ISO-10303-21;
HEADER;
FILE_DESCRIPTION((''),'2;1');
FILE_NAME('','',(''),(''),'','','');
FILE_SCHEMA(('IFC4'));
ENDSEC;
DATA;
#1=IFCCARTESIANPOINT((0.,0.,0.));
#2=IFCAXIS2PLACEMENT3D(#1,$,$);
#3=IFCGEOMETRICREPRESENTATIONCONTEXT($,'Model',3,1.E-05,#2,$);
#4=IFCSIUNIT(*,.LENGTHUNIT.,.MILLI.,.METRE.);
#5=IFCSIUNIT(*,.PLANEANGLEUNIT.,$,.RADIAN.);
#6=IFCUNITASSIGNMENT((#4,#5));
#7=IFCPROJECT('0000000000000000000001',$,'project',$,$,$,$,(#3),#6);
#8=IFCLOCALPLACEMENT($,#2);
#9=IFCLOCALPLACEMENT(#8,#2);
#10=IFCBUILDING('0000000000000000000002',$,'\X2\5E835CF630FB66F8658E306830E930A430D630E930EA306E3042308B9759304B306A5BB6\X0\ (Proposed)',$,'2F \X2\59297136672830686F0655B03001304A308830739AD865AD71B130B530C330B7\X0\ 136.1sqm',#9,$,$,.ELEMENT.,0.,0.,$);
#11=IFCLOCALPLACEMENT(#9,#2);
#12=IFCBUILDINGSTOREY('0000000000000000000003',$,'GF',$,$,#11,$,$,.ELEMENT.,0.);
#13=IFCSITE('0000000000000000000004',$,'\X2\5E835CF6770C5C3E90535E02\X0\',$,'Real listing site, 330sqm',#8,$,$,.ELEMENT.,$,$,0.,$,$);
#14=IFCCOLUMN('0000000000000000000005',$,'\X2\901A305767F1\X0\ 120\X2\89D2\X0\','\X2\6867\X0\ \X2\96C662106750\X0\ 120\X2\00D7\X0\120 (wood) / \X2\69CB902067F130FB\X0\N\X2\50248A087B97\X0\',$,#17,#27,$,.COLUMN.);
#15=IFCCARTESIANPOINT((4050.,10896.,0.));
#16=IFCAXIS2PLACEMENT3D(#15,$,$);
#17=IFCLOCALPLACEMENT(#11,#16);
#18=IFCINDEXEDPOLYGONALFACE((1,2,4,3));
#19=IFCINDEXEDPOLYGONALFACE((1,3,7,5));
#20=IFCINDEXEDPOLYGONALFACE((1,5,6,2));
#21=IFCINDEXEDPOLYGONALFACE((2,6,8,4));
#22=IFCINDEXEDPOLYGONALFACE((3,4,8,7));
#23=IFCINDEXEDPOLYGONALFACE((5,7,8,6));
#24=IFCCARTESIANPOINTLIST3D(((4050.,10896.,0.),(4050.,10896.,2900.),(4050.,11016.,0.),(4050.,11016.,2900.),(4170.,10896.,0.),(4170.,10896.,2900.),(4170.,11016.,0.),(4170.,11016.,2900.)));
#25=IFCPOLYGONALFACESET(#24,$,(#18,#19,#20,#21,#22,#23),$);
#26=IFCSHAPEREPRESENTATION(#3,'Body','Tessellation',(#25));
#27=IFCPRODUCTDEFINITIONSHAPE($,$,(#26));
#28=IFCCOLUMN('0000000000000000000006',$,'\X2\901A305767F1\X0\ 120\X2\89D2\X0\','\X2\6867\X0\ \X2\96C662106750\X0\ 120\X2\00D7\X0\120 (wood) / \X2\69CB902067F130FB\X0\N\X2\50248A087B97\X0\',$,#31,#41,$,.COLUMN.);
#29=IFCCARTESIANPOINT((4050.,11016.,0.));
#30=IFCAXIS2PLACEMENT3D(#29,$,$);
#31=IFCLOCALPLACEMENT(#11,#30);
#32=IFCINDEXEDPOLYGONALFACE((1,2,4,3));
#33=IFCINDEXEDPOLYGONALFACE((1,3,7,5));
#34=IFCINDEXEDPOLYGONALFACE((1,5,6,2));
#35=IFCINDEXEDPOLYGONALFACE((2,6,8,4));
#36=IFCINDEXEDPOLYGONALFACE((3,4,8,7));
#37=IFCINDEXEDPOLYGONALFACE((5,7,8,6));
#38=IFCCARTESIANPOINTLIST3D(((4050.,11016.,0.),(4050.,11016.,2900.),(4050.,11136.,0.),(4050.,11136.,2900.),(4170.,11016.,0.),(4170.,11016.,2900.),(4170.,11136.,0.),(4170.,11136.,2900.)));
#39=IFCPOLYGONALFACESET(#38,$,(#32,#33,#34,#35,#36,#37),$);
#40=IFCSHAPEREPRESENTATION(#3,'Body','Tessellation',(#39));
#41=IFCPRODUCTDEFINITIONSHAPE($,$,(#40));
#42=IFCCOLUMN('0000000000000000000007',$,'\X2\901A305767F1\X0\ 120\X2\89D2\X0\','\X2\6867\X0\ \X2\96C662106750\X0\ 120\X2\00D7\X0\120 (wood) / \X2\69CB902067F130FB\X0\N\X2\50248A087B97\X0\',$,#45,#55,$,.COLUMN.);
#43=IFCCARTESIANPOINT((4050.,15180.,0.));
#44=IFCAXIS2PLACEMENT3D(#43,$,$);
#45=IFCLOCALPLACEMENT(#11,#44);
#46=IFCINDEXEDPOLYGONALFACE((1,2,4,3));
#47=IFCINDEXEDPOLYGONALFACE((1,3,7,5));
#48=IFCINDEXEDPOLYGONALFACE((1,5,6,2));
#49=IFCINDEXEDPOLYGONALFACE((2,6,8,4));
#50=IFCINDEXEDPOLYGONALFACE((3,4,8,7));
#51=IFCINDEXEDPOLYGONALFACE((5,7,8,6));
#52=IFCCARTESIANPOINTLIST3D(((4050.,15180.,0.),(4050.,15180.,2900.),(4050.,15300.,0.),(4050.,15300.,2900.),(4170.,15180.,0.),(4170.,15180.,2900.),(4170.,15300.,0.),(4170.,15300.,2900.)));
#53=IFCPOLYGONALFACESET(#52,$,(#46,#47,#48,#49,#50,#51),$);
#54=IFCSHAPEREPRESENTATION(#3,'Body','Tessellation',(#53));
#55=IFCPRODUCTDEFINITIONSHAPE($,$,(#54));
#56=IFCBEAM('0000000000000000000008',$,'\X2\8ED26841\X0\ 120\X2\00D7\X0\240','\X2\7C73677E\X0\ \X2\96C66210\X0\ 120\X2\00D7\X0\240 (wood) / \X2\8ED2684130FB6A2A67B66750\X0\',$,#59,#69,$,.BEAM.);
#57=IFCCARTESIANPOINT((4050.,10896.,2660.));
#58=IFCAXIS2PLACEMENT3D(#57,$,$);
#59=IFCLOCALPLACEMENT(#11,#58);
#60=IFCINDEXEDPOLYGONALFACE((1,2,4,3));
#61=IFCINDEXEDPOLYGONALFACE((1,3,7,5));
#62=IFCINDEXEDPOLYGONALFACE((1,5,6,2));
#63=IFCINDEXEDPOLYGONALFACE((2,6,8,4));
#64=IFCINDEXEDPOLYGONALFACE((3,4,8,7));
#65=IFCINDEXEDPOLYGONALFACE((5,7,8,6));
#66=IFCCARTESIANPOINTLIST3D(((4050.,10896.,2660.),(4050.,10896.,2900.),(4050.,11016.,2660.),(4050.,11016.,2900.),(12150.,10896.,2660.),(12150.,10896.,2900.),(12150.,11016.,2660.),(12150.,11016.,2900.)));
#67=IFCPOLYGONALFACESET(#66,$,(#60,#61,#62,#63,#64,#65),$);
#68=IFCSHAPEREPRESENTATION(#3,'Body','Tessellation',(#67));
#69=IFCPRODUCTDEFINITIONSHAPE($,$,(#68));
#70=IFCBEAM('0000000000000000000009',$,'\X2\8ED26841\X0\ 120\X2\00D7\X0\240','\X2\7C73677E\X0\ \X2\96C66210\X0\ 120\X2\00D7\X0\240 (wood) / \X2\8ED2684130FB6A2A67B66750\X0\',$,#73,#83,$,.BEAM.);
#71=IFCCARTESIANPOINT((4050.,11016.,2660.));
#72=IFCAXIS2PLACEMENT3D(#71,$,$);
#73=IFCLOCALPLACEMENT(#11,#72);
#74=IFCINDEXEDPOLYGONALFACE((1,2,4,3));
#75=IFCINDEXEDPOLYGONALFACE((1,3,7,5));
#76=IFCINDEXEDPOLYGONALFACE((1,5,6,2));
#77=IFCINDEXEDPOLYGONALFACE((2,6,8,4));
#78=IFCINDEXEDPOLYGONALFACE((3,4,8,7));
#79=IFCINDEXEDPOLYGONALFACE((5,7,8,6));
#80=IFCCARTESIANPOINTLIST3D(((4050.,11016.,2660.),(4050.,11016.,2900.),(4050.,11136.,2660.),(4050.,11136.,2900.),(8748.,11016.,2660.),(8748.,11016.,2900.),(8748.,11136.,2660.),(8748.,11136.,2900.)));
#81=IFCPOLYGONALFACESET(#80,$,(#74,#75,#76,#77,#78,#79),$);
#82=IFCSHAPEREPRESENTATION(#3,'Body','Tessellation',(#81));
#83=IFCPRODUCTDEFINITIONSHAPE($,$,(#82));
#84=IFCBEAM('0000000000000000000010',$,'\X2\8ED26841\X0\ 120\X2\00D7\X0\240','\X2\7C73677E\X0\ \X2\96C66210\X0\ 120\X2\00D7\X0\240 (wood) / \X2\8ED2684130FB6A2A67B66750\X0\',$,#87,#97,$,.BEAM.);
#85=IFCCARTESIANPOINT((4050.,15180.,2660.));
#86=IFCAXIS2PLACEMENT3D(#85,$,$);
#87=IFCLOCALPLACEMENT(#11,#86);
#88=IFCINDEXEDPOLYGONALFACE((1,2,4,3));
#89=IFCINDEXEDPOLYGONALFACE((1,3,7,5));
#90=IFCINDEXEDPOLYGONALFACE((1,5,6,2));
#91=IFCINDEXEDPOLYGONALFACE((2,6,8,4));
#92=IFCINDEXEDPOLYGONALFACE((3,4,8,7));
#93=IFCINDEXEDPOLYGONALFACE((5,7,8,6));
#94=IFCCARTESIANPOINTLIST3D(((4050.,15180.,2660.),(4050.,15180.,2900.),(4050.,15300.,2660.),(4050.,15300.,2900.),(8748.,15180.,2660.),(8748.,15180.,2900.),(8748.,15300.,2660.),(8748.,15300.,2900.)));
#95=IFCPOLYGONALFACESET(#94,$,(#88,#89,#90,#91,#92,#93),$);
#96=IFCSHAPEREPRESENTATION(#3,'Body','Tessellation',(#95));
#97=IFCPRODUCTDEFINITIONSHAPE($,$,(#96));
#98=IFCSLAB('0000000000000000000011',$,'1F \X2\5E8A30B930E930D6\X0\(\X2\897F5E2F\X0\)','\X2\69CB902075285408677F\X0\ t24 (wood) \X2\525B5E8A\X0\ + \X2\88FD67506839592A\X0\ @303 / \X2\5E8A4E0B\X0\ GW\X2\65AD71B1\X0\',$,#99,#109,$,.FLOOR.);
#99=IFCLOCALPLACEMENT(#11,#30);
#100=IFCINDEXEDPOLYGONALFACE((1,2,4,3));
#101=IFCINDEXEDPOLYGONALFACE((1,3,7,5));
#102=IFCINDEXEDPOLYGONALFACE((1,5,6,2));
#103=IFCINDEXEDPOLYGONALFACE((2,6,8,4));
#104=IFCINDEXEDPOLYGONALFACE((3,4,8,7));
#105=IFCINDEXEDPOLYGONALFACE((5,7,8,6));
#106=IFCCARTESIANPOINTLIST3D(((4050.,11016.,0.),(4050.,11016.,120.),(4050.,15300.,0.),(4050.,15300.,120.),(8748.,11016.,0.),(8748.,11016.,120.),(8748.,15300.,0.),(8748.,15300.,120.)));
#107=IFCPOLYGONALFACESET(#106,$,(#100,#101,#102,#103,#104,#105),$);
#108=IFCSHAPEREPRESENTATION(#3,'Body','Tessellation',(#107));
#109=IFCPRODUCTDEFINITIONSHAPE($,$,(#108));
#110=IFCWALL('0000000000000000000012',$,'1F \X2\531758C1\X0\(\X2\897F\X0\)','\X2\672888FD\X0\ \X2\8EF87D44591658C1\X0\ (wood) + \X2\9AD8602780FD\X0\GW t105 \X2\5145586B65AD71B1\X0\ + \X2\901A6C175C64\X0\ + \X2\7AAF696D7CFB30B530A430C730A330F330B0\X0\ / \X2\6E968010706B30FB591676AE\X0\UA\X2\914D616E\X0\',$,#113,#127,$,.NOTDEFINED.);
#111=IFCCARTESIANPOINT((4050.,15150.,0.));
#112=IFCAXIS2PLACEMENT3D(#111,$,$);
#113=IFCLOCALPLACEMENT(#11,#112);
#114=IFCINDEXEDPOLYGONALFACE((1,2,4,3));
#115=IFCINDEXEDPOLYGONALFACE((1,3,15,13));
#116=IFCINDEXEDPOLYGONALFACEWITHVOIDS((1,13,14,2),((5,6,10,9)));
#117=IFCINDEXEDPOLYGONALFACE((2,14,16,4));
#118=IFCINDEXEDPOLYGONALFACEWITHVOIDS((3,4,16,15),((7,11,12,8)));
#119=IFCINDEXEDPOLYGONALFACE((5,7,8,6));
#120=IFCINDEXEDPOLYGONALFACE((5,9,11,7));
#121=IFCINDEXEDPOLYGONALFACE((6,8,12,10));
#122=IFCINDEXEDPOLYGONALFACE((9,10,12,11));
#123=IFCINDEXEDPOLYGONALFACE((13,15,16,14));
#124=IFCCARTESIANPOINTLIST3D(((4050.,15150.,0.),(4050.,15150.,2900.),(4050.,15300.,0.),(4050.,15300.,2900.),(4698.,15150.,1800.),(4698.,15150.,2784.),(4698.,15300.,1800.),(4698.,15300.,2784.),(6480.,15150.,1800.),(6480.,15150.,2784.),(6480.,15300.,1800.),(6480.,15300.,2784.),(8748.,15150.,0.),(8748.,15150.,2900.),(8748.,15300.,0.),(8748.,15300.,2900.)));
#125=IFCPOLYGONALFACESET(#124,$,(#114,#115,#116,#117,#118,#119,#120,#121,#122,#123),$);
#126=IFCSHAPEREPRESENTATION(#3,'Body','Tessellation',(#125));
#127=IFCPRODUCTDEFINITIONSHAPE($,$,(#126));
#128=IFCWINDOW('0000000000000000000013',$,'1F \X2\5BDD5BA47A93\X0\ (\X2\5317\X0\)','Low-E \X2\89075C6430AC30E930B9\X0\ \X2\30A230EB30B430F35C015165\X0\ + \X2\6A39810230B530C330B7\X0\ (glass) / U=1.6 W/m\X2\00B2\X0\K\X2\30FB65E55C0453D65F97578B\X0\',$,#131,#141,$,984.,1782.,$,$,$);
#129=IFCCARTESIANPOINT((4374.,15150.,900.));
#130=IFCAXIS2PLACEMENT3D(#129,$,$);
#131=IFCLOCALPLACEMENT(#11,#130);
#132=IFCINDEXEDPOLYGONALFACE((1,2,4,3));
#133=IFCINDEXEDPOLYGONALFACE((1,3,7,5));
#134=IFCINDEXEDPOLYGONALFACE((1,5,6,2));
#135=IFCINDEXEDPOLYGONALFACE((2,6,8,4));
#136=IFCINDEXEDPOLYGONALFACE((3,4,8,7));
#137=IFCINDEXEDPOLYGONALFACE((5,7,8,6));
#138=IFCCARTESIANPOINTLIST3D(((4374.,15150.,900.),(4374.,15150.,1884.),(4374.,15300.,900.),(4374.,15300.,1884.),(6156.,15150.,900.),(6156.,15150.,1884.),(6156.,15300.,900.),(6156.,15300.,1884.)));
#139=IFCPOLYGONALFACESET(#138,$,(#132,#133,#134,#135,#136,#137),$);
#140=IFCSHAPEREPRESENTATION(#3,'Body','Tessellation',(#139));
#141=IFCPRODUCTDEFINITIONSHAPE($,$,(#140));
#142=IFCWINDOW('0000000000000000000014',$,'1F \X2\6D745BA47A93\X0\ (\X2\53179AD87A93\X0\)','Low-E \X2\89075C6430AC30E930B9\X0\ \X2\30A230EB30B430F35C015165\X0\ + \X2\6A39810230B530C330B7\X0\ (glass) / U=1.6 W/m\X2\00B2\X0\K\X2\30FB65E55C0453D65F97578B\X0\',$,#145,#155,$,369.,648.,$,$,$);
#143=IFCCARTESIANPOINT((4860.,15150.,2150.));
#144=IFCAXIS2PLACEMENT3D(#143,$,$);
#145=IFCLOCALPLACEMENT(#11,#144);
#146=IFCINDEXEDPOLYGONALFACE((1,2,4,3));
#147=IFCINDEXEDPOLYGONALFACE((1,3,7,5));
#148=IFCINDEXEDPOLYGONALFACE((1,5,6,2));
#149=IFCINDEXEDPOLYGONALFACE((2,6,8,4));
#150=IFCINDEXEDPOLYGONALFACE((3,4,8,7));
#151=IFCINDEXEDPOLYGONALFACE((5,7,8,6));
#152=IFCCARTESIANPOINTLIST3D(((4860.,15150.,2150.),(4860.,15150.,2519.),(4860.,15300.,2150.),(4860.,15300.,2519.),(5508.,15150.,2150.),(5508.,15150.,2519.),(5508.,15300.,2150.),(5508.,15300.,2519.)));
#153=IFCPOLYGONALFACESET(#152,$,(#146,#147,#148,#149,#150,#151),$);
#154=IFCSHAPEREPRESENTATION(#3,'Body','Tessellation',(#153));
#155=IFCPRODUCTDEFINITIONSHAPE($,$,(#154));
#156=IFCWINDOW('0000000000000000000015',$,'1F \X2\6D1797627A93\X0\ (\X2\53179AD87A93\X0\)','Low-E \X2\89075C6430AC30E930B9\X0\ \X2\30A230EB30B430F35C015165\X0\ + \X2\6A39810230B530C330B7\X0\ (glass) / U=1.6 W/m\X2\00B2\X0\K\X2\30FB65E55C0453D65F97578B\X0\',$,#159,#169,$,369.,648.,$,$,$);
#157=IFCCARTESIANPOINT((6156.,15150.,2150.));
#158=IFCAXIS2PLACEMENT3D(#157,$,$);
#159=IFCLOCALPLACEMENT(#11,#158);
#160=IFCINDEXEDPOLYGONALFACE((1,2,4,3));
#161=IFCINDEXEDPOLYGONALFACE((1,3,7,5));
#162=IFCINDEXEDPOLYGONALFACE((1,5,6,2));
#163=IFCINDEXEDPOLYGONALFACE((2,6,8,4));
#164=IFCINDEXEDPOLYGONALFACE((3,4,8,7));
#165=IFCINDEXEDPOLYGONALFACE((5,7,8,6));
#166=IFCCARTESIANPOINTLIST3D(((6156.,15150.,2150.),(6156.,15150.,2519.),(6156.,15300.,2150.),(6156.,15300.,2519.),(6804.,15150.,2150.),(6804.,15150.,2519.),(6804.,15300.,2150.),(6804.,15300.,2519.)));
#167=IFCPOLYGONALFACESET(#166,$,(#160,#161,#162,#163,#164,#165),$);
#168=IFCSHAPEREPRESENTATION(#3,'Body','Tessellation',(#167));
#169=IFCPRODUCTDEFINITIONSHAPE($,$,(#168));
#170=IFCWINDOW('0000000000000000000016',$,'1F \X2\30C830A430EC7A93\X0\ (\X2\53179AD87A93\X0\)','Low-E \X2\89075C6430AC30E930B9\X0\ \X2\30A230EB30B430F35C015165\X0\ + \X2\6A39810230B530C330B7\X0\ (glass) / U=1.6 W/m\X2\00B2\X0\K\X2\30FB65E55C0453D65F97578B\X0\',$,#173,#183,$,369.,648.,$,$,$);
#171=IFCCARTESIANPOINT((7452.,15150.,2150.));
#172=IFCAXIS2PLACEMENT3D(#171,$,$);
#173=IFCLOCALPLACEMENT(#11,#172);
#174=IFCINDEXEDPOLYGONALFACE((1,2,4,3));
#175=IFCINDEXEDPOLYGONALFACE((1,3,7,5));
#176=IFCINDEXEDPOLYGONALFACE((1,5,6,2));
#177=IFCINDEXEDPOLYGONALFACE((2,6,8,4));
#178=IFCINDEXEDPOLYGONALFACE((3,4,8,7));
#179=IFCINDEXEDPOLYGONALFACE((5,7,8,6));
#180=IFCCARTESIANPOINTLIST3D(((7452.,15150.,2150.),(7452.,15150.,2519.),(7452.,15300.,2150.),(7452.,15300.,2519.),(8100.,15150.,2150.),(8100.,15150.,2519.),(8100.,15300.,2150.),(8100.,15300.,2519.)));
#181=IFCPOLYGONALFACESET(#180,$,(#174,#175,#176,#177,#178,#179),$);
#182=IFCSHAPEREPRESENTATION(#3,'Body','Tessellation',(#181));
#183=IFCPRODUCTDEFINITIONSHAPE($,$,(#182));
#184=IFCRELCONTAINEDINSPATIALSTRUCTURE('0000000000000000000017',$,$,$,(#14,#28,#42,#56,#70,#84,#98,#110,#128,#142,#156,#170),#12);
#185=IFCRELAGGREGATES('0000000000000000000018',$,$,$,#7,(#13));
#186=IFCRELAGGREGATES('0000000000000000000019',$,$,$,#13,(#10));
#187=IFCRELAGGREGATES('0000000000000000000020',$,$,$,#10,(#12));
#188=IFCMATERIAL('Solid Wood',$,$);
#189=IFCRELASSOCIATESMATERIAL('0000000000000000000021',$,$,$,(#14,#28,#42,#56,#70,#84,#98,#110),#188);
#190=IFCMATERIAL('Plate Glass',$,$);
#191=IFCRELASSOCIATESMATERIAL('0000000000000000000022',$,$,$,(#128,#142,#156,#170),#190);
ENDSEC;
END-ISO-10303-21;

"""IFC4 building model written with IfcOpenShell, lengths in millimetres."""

from ifc_helpers import new_model, si_unit, frame, frame_2d, origin, place, context, project, spatial, rectangle, extrude, material, element, fill, save


model = new_model("IFC4")

# Units and contexts
model_context = context("Model", 3, precision=1e-05, world=origin())
ifc_project = project(units=[si_unit("LENGTHUNIT", "METRE", prefix="MILLI"), si_unit("PLANEANGLEUNIT", "RADIAN")], contexts=[model_context])

# Site, building, storey
site_placement = place(None, origin())
site = spatial("IfcSite", under=ifc_project, at=site_placement, Name="広島県尾道市", ObjectType="Real listing site, 330sqm", CompositionType="ELEMENT", RefElevation=0.0)
building_placement = place(site_placement, origin())
building = spatial("IfcBuilding", under=site, at=building_placement, Name="広島・書斎とライブラリのある静かな家 (Proposed)", ObjectType="2F 天然木と漆喰、および高断熱サッシ 136.1sqm", CompositionType="ELEMENT", ElevationOfRefHeight=0.0, ElevationOfTerrain=0.0)
storey_placement = place(building_placement, origin())
storey = spatial("IfcBuildingStorey", under=building, at=storey_placement, Name="GF", CompositionType="ELEMENT", Elevation=0.0)

# Columns
ifc_material_1 = material(Name="Solid Wood")
column_1_placement = place(storey_placement, frame((4050.0, 10896.0, 0.0)))
element("IfcColumn", 1, at=column_1_placement, inside=storey, material=ifc_material_1, Name="通し柱 120角", Description="桧 集成材 120×120 (wood) / 構造柱・N値計算", PredefinedType="COLUMN", context=model_context, shape_type="SweptSolid", body=[
    extrude(rectangle(XDim=120.0, YDim=120.0, at=frame_2d((60.0, 60.0))), frame((4050.0, 10896.0, 0.0)), (0.0, 0.0, 1.0), 2900.0),
])
column_2_placement = place(storey_placement, frame((4050.0, 11016.0, 0.0)))
element("IfcColumn", 2, at=column_2_placement, inside=storey, material=ifc_material_1, Name="通し柱 120角", Description="桧 集成材 120×120 (wood) / 構造柱・N値計算", PredefinedType="COLUMN", context=model_context, shape_type="SweptSolid", body=[
    extrude(rectangle(XDim=120.0, YDim=120.0, at=frame_2d((60.0, 60.0))), frame((4050.0, 11016.0, 0.0)), (0.0, 0.0, 1.0), 2900.0),
])
column_3_placement = place(storey_placement, frame((4050.0, 15180.0, 0.0)))
element("IfcColumn", 3, at=column_3_placement, inside=storey, material=ifc_material_1, Name="通し柱 120角", Description="桧 集成材 120×120 (wood) / 構造柱・N値計算", PredefinedType="COLUMN", context=model_context, shape_type="SweptSolid", body=[
    extrude(rectangle(XDim=120.0, YDim=120.0, at=frame_2d((60.0, 60.0))), frame((4050.0, 15180.0, 0.0)), (0.0, 0.0, 1.0), 2900.0),
])

# Beams
beam_1_placement = place(storey_placement, frame((4050.0, 10896.0, 2660.0)))
element("IfcBeam", 4, at=beam_1_placement, inside=storey, material=ifc_material_1, Name="軒桁 120×240", Description="米松 集成 120×240 (wood) / 軒桁・横架材", PredefinedType="BEAM", context=model_context, shape_type="SweptSolid", body=[
    extrude(rectangle(XDim=8100.0, YDim=120.0, at=frame_2d((4050.0, 60.0))), frame((4050.0, 10896.0, 2660.0)), (0.0, 0.0, 1.0), 240.0),
])
beam_2_placement = place(storey_placement, frame((4050.0, 11016.0, 2660.0)))
element("IfcBeam", 5, at=beam_2_placement, inside=storey, material=ifc_material_1, Name="軒桁 120×240", Description="米松 集成 120×240 (wood) / 軒桁・横架材", PredefinedType="BEAM", context=model_context, shape_type="SweptSolid", body=[
    extrude(rectangle(XDim=4698.0, YDim=120.0, at=frame_2d((2349.0, 60.0))), frame((4050.0, 11016.0, 2660.0)), (0.0, 0.0, 1.0), 240.0),
])
beam_3_placement = place(storey_placement, frame((4050.0, 15180.0, 2660.0)))
element("IfcBeam", 6, at=beam_3_placement, inside=storey, material=ifc_material_1, Name="軒桁 120×240", Description="米松 集成 120×240 (wood) / 軒桁・横架材", PredefinedType="BEAM", context=model_context, shape_type="SweptSolid", body=[
    extrude(rectangle(XDim=4698.0, YDim=120.0, at=frame_2d((2349.0, 60.0))), frame((4050.0, 15180.0, 2660.0)), (0.0, 0.0, 1.0), 240.0),
])

# Slab
slab_placement = place(storey_placement, frame((4050.0, 11016.0, 0.0)))
element("IfcSlab", 7, at=slab_placement, inside=storey, material=ifc_material_1, Name="1F 床スラブ(西帯)", Description="構造用合板 t24 (wood) 剛床 + 製材根太 @303 / 床下 GW断熱", PredefinedType="FLOOR", context=model_context, shape_type="SweptSolid", body=[
    extrude(rectangle(XDim=4698.0, YDim=4284.0, at=frame_2d((2349.0, 2142.0))), frame((4050.0, 11016.0, 0.0)), (0.0, 0.0, 1.0), 120.0),
])

# Wall, openings, windows
wall_1_placement = place(storey_placement, frame((4050.0, 15150.0, 0.0)))
wall_1 = element("IfcWall", 8, at=wall_1_placement, inside=storey, material=ifc_material_1, Name="1F 北壁(西)", Description="木製 軸組外壁 (wood) + 高性能GW t105 充填断熱 + 通気層 + 窯業系サイディング / 準耐火・外皮UA配慮", PredefinedType="NOTDEFINED", context=model_context, shape_type="SweptSolid", body=[
    extrude(rectangle(XDim=4698.0, YDim=150.0, at=frame_2d((2349.0, 75.0))), frame((4050.0, 15150.0, 0.0)), (0.0, 0.0, 1.0), 2900.0),
])
opening_1_placement = place(storey_placement, frame((4374.0, 15150.0, 900.0)))
opening_1 = element("IfcOpeningElement", 9, at=opening_1_placement, cuts=wall_1, PredefinedType="NOTDEFINED", context=model_context, shape_type="SweptSolid", body=[
    extrude(rectangle(XDim=1782.0, YDim=150.0, at=frame_2d((891.0, 75.0))), frame((4374.0, 15150.0, 900.0)), (0.0, 0.0, 1.0), 984.0),
])
opening_2_placement = place(storey_placement, frame((4860.0, 15150.0, 2150.0)))
opening_2 = element("IfcOpeningElement", 10, at=opening_2_placement, cuts=wall_1, PredefinedType="NOTDEFINED", context=model_context, shape_type="SweptSolid", body=[
    extrude(rectangle(XDim=648.0, YDim=150.0, at=frame_2d((324.0, 75.0))), frame((4860.0, 15150.0, 2150.0)), (0.0, 0.0, 1.0), 369.0),
])
opening_3_placement = place(storey_placement, frame((6156.0, 15150.0, 2150.0)))
opening_3 = element("IfcOpeningElement", 11, at=opening_3_placement, cuts=wall_1, PredefinedType="NOTDEFINED", context=model_context, shape_type="SweptSolid", body=[
    extrude(rectangle(XDim=648.0, YDim=150.0, at=frame_2d((324.0, 75.0))), frame((6156.0, 15150.0, 2150.0)), (0.0, 0.0, 1.0), 369.0),
])
opening_4_placement = place(storey_placement, frame((7452.0, 15150.0, 2150.0)))
opening_4 = element("IfcOpeningElement", 12, at=opening_4_placement, cuts=wall_1, PredefinedType="NOTDEFINED", context=model_context, shape_type="SweptSolid", body=[
    extrude(rectangle(XDim=648.0, YDim=150.0, at=frame_2d((324.0, 75.0))), frame((7452.0, 15150.0, 2150.0)), (0.0, 0.0, 1.0), 369.0),
])
ifc_material_2 = material(Name="Plate Glass")
window_1_placement = place(storey_placement, frame((4374.0, 15150.0, 900.0)))
window_1 = element("IfcWindow", 13, at=window_1_placement, inside=storey, material=ifc_material_2, Name="1F 寝室窓 (北)", Description="Low-E 複層ガラス アルゴン封入 + 樹脂サッシ (glass) / U=1.6 W/m²K・日射取得型", OverallHeight=984.0, OverallWidth=1782.0, context=model_context, shape_type="SweptSolid", body=[
    extrude(rectangle(XDim=1782.0, YDim=150.0, at=frame_2d((891.0, 75.0))), frame((4374.0, 15150.0, 900.0)), (0.0, 0.0, 1.0), 984.0),
])
fill(opening_1, window_1)
window_2_placement = place(storey_placement, frame((4860.0, 15150.0, 2150.0)))
window_2 = element("IfcWindow", 14, at=window_2_placement, inside=storey, material=ifc_material_2, Name="1F 浴室窓 (北高窓)", Description="Low-E 複層ガラス アルゴン封入 + 樹脂サッシ (glass) / U=1.6 W/m²K・日射取得型", OverallHeight=369.0, OverallWidth=648.0, context=model_context, shape_type="SweptSolid", body=[
    extrude(rectangle(XDim=648.0, YDim=150.0, at=frame_2d((324.0, 75.0))), frame((4860.0, 15150.0, 2150.0)), (0.0, 0.0, 1.0), 369.0),
])
fill(opening_2, window_2)
window_3_placement = place(storey_placement, frame((6156.0, 15150.0, 2150.0)))
window_3 = element("IfcWindow", 15, at=window_3_placement, inside=storey, material=ifc_material_2, Name="1F 洗面窓 (北高窓)", Description="Low-E 複層ガラス アルゴン封入 + 樹脂サッシ (glass) / U=1.6 W/m²K・日射取得型", OverallHeight=369.0, OverallWidth=648.0, context=model_context, shape_type="SweptSolid", body=[
    extrude(rectangle(XDim=648.0, YDim=150.0, at=frame_2d((324.0, 75.0))), frame((6156.0, 15150.0, 2150.0)), (0.0, 0.0, 1.0), 369.0),
])
fill(opening_3, window_3)
window_4_placement = place(storey_placement, frame((7452.0, 15150.0, 2150.0)))
window_4 = element("IfcWindow", 16, at=window_4_placement, inside=storey, material=ifc_material_2, Name="1F トイレ窓 (北高窓)", Description="Low-E 複層ガラス アルゴン封入 + 樹脂サッシ (glass) / U=1.6 W/m²K・日射取得型", OverallHeight=369.0, OverallWidth=648.0, context=model_context, shape_type="SweptSolid", body=[
    extrude(rectangle(XDim=648.0, YDim=150.0, at=frame_2d((324.0, 75.0))), frame((7452.0, 15150.0, 2150.0)), (0.0, 0.0, 1.0), 369.0),
])
fill(opening_4, window_4)

save(model, "model.ifc")
